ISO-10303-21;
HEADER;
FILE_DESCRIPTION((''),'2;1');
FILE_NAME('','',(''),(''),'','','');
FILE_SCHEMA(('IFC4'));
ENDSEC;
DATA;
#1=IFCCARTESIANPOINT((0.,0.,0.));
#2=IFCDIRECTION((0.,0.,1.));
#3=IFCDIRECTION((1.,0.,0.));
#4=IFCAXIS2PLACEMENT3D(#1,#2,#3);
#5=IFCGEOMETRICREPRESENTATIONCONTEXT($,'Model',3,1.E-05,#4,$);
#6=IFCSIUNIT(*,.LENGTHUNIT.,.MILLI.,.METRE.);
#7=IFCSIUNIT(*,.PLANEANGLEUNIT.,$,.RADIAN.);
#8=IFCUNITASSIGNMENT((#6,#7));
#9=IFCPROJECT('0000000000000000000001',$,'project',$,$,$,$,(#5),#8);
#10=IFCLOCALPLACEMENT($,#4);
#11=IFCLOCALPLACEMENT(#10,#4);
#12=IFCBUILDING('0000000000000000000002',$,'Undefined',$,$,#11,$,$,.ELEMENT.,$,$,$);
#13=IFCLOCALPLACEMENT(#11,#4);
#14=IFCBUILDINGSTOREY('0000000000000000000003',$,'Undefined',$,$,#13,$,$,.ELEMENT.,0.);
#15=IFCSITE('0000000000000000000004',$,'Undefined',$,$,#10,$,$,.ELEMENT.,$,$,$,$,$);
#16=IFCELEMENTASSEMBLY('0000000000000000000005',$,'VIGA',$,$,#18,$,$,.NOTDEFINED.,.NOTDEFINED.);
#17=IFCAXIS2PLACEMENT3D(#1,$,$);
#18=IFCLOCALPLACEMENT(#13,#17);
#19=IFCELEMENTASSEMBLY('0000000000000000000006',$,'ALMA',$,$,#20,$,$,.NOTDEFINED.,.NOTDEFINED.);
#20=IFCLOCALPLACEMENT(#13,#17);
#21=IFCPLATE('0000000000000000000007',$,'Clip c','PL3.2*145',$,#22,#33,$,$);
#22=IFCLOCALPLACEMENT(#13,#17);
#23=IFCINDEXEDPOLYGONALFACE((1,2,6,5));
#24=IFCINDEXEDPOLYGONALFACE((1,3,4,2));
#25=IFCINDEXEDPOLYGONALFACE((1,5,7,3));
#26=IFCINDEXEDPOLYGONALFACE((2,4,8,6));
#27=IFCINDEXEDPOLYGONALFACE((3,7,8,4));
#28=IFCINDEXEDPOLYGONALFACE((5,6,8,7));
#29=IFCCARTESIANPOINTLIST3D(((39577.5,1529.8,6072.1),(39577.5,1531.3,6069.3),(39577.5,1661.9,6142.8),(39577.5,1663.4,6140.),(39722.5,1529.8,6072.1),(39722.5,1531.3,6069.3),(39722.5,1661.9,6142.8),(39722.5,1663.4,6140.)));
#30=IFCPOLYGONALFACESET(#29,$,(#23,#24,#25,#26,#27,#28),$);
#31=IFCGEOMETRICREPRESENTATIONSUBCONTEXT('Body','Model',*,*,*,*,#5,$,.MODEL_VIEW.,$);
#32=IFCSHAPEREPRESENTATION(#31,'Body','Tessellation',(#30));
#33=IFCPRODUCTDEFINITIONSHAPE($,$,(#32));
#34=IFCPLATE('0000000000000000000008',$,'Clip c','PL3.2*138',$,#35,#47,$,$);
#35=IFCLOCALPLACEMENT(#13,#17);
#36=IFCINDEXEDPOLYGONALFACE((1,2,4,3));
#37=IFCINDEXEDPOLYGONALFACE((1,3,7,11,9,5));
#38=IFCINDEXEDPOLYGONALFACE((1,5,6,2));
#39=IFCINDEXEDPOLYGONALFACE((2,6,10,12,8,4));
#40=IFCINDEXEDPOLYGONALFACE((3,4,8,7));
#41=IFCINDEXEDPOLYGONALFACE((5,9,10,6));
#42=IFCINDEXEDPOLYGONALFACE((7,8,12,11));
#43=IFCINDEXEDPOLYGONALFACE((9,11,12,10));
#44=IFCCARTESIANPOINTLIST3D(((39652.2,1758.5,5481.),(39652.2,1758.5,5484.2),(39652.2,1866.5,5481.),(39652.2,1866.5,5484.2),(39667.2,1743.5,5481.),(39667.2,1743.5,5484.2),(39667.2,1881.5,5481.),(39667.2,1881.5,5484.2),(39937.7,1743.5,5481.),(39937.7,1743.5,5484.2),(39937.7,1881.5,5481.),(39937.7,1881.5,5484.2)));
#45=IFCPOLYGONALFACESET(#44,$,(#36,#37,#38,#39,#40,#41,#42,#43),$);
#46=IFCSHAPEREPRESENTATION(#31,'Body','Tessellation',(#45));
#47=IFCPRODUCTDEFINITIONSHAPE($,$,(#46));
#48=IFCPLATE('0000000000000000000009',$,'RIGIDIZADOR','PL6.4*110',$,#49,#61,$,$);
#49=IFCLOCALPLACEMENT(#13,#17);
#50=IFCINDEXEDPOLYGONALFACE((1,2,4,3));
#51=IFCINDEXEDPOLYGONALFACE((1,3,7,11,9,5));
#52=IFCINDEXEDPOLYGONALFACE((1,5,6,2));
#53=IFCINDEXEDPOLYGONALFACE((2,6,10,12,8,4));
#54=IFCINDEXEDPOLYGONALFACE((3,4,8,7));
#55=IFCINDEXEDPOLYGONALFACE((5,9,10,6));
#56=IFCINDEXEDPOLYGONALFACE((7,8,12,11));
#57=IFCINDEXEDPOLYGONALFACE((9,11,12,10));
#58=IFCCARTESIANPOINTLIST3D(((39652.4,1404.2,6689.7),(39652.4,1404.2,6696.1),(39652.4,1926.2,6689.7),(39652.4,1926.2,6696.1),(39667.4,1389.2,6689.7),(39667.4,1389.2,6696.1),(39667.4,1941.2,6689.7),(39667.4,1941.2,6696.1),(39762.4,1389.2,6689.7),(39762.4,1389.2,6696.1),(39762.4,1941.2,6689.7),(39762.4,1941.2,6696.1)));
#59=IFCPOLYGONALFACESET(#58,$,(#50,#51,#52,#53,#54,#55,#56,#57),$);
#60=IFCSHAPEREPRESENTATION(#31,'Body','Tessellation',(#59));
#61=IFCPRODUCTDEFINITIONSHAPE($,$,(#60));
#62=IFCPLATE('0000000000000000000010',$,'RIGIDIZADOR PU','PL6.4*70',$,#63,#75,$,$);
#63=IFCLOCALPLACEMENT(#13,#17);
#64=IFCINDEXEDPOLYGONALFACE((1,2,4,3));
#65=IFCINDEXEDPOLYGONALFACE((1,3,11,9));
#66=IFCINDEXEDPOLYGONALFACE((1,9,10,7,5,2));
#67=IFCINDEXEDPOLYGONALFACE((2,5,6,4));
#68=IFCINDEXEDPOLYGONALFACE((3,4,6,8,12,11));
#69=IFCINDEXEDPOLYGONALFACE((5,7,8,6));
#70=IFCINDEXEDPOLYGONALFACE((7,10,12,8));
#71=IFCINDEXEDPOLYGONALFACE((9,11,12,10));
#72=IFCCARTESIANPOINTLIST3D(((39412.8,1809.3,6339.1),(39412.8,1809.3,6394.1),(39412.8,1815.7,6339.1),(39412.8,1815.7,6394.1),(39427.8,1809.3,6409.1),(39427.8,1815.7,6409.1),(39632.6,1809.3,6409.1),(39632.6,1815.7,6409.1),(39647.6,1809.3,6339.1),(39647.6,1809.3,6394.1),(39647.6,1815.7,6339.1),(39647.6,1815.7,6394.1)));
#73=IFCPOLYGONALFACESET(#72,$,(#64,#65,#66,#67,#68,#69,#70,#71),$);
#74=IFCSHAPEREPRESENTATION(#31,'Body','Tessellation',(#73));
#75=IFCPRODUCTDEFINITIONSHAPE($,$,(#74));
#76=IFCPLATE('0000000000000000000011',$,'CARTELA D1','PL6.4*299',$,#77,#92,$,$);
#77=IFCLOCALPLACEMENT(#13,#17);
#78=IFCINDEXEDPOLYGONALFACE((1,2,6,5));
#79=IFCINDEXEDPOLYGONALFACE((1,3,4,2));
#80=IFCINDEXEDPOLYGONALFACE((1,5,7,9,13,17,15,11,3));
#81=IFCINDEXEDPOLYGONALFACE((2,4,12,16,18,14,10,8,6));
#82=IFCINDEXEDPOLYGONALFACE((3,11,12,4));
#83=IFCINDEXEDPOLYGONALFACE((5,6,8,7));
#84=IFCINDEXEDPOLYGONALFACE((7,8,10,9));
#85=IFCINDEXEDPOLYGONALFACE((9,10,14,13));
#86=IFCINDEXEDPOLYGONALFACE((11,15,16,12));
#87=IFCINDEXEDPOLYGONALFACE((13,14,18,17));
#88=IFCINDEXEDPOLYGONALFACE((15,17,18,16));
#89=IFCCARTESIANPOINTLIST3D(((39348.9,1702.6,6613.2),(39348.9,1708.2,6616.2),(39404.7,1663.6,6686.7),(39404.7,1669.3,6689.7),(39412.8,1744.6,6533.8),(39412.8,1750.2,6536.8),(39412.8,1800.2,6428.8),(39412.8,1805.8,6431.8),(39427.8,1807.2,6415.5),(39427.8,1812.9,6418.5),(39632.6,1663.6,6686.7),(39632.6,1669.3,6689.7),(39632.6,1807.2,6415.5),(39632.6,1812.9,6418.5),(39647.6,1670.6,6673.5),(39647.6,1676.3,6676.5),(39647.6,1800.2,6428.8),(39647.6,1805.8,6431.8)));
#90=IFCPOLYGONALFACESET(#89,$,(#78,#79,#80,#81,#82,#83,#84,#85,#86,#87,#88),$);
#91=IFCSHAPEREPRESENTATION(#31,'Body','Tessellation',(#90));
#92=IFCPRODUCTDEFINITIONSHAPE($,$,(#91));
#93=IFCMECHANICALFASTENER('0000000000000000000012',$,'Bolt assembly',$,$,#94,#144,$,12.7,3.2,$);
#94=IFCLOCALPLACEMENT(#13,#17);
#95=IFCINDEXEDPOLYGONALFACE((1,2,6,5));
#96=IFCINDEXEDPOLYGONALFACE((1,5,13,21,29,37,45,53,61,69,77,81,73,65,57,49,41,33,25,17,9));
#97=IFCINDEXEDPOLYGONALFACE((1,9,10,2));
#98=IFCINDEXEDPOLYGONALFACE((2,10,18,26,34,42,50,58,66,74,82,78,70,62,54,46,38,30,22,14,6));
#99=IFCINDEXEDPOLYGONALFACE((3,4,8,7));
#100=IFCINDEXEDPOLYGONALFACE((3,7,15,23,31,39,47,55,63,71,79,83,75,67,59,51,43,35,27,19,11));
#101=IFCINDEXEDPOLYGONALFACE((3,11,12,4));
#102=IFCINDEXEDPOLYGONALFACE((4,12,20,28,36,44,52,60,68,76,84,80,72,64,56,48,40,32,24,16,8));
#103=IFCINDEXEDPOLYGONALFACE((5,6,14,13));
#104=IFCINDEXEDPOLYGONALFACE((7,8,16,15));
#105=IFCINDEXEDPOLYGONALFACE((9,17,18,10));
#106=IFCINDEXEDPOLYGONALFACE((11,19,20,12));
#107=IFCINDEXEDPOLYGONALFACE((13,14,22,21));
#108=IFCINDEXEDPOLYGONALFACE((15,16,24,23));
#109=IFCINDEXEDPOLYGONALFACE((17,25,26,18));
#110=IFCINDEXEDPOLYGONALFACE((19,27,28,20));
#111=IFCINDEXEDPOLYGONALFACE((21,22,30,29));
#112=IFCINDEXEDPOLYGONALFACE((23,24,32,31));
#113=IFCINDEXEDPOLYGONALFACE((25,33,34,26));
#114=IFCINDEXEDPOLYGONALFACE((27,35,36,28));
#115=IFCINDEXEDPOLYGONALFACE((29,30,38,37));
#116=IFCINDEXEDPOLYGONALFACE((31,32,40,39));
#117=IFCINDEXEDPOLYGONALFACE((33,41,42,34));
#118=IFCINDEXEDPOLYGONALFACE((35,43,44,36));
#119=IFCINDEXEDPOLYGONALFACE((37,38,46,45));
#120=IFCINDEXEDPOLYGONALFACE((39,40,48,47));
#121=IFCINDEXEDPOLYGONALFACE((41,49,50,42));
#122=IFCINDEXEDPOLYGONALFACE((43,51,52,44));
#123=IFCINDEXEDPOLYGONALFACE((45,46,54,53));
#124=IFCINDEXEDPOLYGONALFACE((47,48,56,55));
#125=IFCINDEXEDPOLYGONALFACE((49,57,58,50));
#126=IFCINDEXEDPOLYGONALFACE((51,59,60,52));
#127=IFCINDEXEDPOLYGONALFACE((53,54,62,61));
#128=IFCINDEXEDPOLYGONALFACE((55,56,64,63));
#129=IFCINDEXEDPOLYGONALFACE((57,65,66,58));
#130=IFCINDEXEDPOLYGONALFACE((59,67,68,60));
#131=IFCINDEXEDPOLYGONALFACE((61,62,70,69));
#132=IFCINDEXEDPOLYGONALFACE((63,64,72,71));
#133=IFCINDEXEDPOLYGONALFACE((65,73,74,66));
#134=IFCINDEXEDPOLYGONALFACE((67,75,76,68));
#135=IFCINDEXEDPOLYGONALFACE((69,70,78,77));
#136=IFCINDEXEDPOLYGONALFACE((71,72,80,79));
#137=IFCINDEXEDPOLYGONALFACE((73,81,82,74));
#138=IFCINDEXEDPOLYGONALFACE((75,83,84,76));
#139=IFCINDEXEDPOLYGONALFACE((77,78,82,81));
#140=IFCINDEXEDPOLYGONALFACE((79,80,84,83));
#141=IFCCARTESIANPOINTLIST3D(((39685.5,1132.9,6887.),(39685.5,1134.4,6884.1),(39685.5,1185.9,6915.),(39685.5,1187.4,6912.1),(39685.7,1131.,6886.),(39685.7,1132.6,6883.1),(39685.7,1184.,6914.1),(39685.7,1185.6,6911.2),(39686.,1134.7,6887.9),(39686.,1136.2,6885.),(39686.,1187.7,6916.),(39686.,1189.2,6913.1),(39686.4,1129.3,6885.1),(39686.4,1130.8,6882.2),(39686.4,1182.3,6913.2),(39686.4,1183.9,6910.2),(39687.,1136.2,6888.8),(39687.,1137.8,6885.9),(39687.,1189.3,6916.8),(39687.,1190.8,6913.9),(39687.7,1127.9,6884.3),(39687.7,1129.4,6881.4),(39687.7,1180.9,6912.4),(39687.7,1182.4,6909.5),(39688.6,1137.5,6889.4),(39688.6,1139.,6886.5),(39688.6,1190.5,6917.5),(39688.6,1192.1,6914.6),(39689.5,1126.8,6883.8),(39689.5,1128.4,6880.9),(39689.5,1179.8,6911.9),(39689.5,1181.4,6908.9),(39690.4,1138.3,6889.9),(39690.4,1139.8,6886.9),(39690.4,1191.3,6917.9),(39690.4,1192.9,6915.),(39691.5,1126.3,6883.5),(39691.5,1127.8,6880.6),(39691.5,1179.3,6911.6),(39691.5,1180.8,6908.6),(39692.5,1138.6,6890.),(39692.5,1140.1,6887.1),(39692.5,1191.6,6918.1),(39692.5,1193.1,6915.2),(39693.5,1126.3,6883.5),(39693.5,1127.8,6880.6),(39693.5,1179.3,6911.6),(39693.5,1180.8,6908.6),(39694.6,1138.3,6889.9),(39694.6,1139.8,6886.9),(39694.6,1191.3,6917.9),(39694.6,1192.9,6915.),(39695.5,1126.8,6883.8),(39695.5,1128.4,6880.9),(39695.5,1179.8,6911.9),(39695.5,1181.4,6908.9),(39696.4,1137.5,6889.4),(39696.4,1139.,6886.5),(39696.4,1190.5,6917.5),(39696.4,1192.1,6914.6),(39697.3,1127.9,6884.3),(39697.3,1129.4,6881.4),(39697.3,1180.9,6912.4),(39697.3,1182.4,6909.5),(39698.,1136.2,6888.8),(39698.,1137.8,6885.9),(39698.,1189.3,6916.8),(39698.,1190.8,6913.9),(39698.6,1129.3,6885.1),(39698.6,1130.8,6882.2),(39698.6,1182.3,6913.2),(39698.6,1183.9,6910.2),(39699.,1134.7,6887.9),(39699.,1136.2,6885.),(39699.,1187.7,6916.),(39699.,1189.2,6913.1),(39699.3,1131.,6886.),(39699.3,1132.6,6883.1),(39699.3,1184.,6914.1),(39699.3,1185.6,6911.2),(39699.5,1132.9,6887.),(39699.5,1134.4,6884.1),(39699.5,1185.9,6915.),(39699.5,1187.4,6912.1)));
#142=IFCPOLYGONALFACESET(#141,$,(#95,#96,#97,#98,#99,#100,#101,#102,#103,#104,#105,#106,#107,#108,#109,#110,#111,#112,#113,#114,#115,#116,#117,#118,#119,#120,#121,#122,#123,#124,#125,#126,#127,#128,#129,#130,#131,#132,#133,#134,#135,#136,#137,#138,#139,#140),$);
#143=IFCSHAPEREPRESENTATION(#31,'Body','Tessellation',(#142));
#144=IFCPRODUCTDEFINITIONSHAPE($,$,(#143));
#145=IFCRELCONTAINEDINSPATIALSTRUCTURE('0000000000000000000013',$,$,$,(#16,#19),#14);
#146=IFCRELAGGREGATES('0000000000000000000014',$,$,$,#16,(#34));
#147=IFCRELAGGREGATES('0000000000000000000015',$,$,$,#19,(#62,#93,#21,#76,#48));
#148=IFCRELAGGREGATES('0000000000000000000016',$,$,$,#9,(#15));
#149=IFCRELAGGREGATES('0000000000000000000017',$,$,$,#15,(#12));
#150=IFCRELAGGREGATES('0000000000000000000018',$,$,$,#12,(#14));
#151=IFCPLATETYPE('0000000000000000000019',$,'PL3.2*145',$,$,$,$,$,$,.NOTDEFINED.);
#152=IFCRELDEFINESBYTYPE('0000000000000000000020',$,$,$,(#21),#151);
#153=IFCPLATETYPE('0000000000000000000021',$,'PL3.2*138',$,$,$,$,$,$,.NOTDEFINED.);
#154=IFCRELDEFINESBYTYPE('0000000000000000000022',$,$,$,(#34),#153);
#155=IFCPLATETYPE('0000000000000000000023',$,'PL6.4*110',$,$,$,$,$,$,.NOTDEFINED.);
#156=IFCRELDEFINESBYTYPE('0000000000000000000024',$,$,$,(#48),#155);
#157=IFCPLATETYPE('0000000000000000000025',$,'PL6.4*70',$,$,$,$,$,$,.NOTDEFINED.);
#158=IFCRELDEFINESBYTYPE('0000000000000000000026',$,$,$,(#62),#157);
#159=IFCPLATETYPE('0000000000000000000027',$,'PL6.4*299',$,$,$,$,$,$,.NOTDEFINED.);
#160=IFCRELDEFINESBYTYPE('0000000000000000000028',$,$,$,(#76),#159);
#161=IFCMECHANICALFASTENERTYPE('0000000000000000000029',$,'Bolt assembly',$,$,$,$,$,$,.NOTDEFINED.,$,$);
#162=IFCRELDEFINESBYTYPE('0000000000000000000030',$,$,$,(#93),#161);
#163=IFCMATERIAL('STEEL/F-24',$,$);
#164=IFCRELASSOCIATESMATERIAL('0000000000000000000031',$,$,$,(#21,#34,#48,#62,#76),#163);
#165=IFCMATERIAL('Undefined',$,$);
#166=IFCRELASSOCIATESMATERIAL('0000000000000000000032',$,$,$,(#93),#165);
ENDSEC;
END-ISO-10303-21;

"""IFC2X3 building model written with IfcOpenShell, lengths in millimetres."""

from ifc_helpers import new_model, si_unit, frame, origin_with_axes, origin_2d_with_axis, place, context, subcontext, project, spatial, polyline, circle, outline, extrude, source, transform, mapped, material, type_object, element, aggregate, save


model = new_model("IFC2X3")

# Units and contexts
model_context = context("Model", 3, precision=1e-05, world=origin_with_axes())
body_context = subcontext(model_context, "Body", "Model", "MODEL_VIEW")
ifc_project = project(units=[si_unit("LENGTHUNIT", "METRE", prefix="MILLI"), si_unit("PLANEANGLEUNIT", "RADIAN")], contexts=[model_context])

# Site, building, storey
site_placement = place(None, origin_with_axes())
site = spatial("IfcSite", under=ifc_project, at=site_placement, Name="Undefined", CompositionType="ELEMENT")
building_placement = place(site_placement, origin_with_axes())
building = spatial("IfcBuilding", under=site, at=building_placement, Name="Undefined", CompositionType="ELEMENT")
storey_placement = place(building_placement, origin_with_axes())
storey = spatial("IfcBuildingStorey", under=building, at=storey_placement, Name="Undefined", CompositionType="ELEMENT", Elevation=0.0)

# Element assembly
assembly_1_placement = place(storey_placement, origin_with_axes())
assembly_1 = element("IfcElementAssembly", 1, at=assembly_1_placement, inside=storey, Name="VIGA", AssemblyPlace="NOTDEFINED", PredefinedType="NOTDEFINED")
ifc_material_1 = material(Name="STEEL/F-24")

# Element assembly
assembly_2_placement = place(storey_placement, origin_with_axes())
assembly_2 = element("IfcElementAssembly", 2, at=assembly_2_placement, inside=storey, Name="ALMA", AssemblyPlace="NOTDEFINED", PredefinedType="NOTDEFINED")

# Plates
plate_type_1 = type_object("IfcPlateType", Name="PL3.2*145", PredefinedType="NOTDEFINED")
plate_1_placement = place(assembly_2_placement, frame((39722.5, 1662.7, 6141.4), z_axis=(0.0, 0.471594, -0.881816), x_axis=(0.0, -0.881816, -0.471594)))
plate_1 = element("IfcPlate", 3, at=plate_1_placement, type_object=plate_type_1, material=ifc_material_1, Name="Clip c", Description="PL3.2*145", context=body_context, shape_type="SweptSolid", body=[
    extrude(outline(polyline([(0.0, 0.0), (149.8, 0.0), (149.8, 145.0), (0.0, 145.0), (0.0, 0.0)])), frame((0.0, 0.0, -1.6), z_axis=(0.0, 0.0, 1.0), x_axis=(1.0, 0.0, 0.0)), (0.0, 0.0, 1.0), 3.2),
])
plate_type_2 = type_object("IfcPlateType", Name="PL3.2*138", PredefinedType="NOTDEFINED")
plate_2_placement = place(assembly_1_placement, frame((39652.2, 1743.5, 5482.6), z_axis=(-0.00012, 0.0, 1.0), x_axis=(1.0, 0.0, 0.00012)))
plate_2 = element("IfcPlate", 4, at=plate_2_placement, type_object=plate_type_2, material=ifc_material_1, Name="Clip c", Description="PL3.2*138", context=body_context, shape_type="SweptSolid", body=[
    extrude(outline(polyline([(0.0, 15.0), (15.0, 0.0), (285.5, 0.0), (285.5, 138.0), (15.0, 138.0), (0.0, 123.0), (0.0, 15.0)])), frame((0.0, 0.0, -1.6), z_axis=(0.0, 0.0, 1.0), x_axis=(1.0, 0.0, 0.0)), (0.0, 0.0, 1.0), 3.2),
])
aggregate(assembly_1, [plate_2])
plate_type_3 = type_object("IfcPlateType", Name="PL6.4*110", PredefinedType="NOTDEFINED")
plate_3_placement = place(assembly_2_placement, frame((39762.4, 1941.2, 6692.9), z_axis=(0.0, 0.0, 1.0), x_axis=(-1.0, 0.0, 0.0)))
plate_3 = element("IfcPlate", 5, at=plate_3_placement, type_object=plate_type_3, material=ifc_material_1, Name="RIGIDIZADOR", Description="PL6.4*110", context=body_context, shape_type="SweptSolid", body=[
    extrude(outline(polyline([(0.0, 0.0), (95.0, 0.0), (110.0, 15.0), (110.0, 537.0), (95.0, 552.0), (0.0, 552.0), (0.0, 0.0)])), frame((0.0, 0.0, -3.2), z_axis=(0.0, 0.0, 1.0), x_axis=(1.0, 0.0, 0.0)), (0.0, 0.0, 1.0), 6.4),
])
plate_type_4 = type_object("IfcPlateType", Name="PL6.4*70", PredefinedType="NOTDEFINED")
plate_4_placement = place(assembly_2_placement, frame((39647.6, 1812.5, 6409.1), z_axis=(-0.000003, -1.0, 0.0), x_axis=(-1.0, 0.000003, 0.0)))
plate_4 = element("IfcPlate", 6, at=plate_4_placement, type_object=plate_type_4, material=ifc_material_1, Name="RIGIDIZADOR PU", Description="PL6.4*70", context=body_context, shape_type="SweptSolid", body=[
    extrude(outline(polyline([(0.0, 15.0), (15.0, 0.0), (219.8, 0.0), (234.8, 15.0), (234.8, 70.0), (0.0, 70.0), (0.0, 15.0)])), frame((0.0, 0.0, -3.2), z_axis=(0.0, 0.0, 1.0), x_axis=(1.0, 0.0, 0.0)), (0.0, 0.0, 1.0), 6.4),
])
plate_type_5 = type_object("IfcPlateType", Name="PL6.4*299", PredefinedType="NOTDEFINED")
plate_5_placement = place(assembly_2_placement, frame((39647.6, 1666.4, 6688.2), z_axis=(-0.000001, 0.883788, 0.467887), x_axis=(0.0, 0.467887, -0.883788)))
plate_5 = element("IfcPlate", 7, at=plate_5_placement, type_object=plate_type_5, material=ifc_material_1, Name="CARTELA D1", Description="PL6.4*299", context=body_context, shape_type="SweptSolid", body=[
    extrude(outline(polyline([(0.0, 15.0), (15.0, 0.0), (291.9, 0.0), (306.9, 15.0), (306.9, 219.8), (291.9, 234.8), (173.0, 234.8), (83.2, 298.7), (0.0, 242.9), (0.0, 15.0)])), frame((0.0, 0.0, -3.2), z_axis=(0.0, 0.0, 1.0), x_axis=(1.0, 0.0, 0.0)), (0.0, 0.0, 1.0), 6.4),
])

# Shared definitions
ifc_material_2 = material(Name="Undefined")
mechanical_fastener_type = type_object("IfcMechanicalFastenerType", Name="Bolt assembly")

# Mechanical fastener
shared_shape_1 = source(origin_with_axes(), body_context, "Body", "SweptSolid", [
    extrude(circle(Radius=7.0, at=origin_2d_with_axis()), frame((0.0, -2.2, 0.0), z_axis=(0.0, 1.0, 0.0), x_axis=(1.0, 0.0, 0.0)), (0.0, 0.0, 1.0), 3.3),
])
mechanical_fastener_1_placement = place(assembly_2_placement, frame((39692.5, 1132.9, 6885.8), z_axis=(1.0, 0.0, 0.0), x_axis=(0.0, 0.883795, 0.467875)))
mechanical_fastener_1 = element("IfcMechanicalFastener", 8, at=mechanical_fastener_1_placement, type_object=mechanical_fastener_type, material=ifc_material_2, Name="Bolt assembly", NominalDiameter=12.7, NominalLength=3.2, context=body_context, shape_type="MappedRepresentation", body=[
    mapped(shared_shape_1, transform((0.0, 0.0, 0.0))),
    mapped(shared_shape_1, transform((60.0, 0.0, 0.0))),
])

aggregate(assembly_2, [plate_4, mechanical_fastener_1, plate_1, plate_5, plate_3])

save(model, "model.ifc")
